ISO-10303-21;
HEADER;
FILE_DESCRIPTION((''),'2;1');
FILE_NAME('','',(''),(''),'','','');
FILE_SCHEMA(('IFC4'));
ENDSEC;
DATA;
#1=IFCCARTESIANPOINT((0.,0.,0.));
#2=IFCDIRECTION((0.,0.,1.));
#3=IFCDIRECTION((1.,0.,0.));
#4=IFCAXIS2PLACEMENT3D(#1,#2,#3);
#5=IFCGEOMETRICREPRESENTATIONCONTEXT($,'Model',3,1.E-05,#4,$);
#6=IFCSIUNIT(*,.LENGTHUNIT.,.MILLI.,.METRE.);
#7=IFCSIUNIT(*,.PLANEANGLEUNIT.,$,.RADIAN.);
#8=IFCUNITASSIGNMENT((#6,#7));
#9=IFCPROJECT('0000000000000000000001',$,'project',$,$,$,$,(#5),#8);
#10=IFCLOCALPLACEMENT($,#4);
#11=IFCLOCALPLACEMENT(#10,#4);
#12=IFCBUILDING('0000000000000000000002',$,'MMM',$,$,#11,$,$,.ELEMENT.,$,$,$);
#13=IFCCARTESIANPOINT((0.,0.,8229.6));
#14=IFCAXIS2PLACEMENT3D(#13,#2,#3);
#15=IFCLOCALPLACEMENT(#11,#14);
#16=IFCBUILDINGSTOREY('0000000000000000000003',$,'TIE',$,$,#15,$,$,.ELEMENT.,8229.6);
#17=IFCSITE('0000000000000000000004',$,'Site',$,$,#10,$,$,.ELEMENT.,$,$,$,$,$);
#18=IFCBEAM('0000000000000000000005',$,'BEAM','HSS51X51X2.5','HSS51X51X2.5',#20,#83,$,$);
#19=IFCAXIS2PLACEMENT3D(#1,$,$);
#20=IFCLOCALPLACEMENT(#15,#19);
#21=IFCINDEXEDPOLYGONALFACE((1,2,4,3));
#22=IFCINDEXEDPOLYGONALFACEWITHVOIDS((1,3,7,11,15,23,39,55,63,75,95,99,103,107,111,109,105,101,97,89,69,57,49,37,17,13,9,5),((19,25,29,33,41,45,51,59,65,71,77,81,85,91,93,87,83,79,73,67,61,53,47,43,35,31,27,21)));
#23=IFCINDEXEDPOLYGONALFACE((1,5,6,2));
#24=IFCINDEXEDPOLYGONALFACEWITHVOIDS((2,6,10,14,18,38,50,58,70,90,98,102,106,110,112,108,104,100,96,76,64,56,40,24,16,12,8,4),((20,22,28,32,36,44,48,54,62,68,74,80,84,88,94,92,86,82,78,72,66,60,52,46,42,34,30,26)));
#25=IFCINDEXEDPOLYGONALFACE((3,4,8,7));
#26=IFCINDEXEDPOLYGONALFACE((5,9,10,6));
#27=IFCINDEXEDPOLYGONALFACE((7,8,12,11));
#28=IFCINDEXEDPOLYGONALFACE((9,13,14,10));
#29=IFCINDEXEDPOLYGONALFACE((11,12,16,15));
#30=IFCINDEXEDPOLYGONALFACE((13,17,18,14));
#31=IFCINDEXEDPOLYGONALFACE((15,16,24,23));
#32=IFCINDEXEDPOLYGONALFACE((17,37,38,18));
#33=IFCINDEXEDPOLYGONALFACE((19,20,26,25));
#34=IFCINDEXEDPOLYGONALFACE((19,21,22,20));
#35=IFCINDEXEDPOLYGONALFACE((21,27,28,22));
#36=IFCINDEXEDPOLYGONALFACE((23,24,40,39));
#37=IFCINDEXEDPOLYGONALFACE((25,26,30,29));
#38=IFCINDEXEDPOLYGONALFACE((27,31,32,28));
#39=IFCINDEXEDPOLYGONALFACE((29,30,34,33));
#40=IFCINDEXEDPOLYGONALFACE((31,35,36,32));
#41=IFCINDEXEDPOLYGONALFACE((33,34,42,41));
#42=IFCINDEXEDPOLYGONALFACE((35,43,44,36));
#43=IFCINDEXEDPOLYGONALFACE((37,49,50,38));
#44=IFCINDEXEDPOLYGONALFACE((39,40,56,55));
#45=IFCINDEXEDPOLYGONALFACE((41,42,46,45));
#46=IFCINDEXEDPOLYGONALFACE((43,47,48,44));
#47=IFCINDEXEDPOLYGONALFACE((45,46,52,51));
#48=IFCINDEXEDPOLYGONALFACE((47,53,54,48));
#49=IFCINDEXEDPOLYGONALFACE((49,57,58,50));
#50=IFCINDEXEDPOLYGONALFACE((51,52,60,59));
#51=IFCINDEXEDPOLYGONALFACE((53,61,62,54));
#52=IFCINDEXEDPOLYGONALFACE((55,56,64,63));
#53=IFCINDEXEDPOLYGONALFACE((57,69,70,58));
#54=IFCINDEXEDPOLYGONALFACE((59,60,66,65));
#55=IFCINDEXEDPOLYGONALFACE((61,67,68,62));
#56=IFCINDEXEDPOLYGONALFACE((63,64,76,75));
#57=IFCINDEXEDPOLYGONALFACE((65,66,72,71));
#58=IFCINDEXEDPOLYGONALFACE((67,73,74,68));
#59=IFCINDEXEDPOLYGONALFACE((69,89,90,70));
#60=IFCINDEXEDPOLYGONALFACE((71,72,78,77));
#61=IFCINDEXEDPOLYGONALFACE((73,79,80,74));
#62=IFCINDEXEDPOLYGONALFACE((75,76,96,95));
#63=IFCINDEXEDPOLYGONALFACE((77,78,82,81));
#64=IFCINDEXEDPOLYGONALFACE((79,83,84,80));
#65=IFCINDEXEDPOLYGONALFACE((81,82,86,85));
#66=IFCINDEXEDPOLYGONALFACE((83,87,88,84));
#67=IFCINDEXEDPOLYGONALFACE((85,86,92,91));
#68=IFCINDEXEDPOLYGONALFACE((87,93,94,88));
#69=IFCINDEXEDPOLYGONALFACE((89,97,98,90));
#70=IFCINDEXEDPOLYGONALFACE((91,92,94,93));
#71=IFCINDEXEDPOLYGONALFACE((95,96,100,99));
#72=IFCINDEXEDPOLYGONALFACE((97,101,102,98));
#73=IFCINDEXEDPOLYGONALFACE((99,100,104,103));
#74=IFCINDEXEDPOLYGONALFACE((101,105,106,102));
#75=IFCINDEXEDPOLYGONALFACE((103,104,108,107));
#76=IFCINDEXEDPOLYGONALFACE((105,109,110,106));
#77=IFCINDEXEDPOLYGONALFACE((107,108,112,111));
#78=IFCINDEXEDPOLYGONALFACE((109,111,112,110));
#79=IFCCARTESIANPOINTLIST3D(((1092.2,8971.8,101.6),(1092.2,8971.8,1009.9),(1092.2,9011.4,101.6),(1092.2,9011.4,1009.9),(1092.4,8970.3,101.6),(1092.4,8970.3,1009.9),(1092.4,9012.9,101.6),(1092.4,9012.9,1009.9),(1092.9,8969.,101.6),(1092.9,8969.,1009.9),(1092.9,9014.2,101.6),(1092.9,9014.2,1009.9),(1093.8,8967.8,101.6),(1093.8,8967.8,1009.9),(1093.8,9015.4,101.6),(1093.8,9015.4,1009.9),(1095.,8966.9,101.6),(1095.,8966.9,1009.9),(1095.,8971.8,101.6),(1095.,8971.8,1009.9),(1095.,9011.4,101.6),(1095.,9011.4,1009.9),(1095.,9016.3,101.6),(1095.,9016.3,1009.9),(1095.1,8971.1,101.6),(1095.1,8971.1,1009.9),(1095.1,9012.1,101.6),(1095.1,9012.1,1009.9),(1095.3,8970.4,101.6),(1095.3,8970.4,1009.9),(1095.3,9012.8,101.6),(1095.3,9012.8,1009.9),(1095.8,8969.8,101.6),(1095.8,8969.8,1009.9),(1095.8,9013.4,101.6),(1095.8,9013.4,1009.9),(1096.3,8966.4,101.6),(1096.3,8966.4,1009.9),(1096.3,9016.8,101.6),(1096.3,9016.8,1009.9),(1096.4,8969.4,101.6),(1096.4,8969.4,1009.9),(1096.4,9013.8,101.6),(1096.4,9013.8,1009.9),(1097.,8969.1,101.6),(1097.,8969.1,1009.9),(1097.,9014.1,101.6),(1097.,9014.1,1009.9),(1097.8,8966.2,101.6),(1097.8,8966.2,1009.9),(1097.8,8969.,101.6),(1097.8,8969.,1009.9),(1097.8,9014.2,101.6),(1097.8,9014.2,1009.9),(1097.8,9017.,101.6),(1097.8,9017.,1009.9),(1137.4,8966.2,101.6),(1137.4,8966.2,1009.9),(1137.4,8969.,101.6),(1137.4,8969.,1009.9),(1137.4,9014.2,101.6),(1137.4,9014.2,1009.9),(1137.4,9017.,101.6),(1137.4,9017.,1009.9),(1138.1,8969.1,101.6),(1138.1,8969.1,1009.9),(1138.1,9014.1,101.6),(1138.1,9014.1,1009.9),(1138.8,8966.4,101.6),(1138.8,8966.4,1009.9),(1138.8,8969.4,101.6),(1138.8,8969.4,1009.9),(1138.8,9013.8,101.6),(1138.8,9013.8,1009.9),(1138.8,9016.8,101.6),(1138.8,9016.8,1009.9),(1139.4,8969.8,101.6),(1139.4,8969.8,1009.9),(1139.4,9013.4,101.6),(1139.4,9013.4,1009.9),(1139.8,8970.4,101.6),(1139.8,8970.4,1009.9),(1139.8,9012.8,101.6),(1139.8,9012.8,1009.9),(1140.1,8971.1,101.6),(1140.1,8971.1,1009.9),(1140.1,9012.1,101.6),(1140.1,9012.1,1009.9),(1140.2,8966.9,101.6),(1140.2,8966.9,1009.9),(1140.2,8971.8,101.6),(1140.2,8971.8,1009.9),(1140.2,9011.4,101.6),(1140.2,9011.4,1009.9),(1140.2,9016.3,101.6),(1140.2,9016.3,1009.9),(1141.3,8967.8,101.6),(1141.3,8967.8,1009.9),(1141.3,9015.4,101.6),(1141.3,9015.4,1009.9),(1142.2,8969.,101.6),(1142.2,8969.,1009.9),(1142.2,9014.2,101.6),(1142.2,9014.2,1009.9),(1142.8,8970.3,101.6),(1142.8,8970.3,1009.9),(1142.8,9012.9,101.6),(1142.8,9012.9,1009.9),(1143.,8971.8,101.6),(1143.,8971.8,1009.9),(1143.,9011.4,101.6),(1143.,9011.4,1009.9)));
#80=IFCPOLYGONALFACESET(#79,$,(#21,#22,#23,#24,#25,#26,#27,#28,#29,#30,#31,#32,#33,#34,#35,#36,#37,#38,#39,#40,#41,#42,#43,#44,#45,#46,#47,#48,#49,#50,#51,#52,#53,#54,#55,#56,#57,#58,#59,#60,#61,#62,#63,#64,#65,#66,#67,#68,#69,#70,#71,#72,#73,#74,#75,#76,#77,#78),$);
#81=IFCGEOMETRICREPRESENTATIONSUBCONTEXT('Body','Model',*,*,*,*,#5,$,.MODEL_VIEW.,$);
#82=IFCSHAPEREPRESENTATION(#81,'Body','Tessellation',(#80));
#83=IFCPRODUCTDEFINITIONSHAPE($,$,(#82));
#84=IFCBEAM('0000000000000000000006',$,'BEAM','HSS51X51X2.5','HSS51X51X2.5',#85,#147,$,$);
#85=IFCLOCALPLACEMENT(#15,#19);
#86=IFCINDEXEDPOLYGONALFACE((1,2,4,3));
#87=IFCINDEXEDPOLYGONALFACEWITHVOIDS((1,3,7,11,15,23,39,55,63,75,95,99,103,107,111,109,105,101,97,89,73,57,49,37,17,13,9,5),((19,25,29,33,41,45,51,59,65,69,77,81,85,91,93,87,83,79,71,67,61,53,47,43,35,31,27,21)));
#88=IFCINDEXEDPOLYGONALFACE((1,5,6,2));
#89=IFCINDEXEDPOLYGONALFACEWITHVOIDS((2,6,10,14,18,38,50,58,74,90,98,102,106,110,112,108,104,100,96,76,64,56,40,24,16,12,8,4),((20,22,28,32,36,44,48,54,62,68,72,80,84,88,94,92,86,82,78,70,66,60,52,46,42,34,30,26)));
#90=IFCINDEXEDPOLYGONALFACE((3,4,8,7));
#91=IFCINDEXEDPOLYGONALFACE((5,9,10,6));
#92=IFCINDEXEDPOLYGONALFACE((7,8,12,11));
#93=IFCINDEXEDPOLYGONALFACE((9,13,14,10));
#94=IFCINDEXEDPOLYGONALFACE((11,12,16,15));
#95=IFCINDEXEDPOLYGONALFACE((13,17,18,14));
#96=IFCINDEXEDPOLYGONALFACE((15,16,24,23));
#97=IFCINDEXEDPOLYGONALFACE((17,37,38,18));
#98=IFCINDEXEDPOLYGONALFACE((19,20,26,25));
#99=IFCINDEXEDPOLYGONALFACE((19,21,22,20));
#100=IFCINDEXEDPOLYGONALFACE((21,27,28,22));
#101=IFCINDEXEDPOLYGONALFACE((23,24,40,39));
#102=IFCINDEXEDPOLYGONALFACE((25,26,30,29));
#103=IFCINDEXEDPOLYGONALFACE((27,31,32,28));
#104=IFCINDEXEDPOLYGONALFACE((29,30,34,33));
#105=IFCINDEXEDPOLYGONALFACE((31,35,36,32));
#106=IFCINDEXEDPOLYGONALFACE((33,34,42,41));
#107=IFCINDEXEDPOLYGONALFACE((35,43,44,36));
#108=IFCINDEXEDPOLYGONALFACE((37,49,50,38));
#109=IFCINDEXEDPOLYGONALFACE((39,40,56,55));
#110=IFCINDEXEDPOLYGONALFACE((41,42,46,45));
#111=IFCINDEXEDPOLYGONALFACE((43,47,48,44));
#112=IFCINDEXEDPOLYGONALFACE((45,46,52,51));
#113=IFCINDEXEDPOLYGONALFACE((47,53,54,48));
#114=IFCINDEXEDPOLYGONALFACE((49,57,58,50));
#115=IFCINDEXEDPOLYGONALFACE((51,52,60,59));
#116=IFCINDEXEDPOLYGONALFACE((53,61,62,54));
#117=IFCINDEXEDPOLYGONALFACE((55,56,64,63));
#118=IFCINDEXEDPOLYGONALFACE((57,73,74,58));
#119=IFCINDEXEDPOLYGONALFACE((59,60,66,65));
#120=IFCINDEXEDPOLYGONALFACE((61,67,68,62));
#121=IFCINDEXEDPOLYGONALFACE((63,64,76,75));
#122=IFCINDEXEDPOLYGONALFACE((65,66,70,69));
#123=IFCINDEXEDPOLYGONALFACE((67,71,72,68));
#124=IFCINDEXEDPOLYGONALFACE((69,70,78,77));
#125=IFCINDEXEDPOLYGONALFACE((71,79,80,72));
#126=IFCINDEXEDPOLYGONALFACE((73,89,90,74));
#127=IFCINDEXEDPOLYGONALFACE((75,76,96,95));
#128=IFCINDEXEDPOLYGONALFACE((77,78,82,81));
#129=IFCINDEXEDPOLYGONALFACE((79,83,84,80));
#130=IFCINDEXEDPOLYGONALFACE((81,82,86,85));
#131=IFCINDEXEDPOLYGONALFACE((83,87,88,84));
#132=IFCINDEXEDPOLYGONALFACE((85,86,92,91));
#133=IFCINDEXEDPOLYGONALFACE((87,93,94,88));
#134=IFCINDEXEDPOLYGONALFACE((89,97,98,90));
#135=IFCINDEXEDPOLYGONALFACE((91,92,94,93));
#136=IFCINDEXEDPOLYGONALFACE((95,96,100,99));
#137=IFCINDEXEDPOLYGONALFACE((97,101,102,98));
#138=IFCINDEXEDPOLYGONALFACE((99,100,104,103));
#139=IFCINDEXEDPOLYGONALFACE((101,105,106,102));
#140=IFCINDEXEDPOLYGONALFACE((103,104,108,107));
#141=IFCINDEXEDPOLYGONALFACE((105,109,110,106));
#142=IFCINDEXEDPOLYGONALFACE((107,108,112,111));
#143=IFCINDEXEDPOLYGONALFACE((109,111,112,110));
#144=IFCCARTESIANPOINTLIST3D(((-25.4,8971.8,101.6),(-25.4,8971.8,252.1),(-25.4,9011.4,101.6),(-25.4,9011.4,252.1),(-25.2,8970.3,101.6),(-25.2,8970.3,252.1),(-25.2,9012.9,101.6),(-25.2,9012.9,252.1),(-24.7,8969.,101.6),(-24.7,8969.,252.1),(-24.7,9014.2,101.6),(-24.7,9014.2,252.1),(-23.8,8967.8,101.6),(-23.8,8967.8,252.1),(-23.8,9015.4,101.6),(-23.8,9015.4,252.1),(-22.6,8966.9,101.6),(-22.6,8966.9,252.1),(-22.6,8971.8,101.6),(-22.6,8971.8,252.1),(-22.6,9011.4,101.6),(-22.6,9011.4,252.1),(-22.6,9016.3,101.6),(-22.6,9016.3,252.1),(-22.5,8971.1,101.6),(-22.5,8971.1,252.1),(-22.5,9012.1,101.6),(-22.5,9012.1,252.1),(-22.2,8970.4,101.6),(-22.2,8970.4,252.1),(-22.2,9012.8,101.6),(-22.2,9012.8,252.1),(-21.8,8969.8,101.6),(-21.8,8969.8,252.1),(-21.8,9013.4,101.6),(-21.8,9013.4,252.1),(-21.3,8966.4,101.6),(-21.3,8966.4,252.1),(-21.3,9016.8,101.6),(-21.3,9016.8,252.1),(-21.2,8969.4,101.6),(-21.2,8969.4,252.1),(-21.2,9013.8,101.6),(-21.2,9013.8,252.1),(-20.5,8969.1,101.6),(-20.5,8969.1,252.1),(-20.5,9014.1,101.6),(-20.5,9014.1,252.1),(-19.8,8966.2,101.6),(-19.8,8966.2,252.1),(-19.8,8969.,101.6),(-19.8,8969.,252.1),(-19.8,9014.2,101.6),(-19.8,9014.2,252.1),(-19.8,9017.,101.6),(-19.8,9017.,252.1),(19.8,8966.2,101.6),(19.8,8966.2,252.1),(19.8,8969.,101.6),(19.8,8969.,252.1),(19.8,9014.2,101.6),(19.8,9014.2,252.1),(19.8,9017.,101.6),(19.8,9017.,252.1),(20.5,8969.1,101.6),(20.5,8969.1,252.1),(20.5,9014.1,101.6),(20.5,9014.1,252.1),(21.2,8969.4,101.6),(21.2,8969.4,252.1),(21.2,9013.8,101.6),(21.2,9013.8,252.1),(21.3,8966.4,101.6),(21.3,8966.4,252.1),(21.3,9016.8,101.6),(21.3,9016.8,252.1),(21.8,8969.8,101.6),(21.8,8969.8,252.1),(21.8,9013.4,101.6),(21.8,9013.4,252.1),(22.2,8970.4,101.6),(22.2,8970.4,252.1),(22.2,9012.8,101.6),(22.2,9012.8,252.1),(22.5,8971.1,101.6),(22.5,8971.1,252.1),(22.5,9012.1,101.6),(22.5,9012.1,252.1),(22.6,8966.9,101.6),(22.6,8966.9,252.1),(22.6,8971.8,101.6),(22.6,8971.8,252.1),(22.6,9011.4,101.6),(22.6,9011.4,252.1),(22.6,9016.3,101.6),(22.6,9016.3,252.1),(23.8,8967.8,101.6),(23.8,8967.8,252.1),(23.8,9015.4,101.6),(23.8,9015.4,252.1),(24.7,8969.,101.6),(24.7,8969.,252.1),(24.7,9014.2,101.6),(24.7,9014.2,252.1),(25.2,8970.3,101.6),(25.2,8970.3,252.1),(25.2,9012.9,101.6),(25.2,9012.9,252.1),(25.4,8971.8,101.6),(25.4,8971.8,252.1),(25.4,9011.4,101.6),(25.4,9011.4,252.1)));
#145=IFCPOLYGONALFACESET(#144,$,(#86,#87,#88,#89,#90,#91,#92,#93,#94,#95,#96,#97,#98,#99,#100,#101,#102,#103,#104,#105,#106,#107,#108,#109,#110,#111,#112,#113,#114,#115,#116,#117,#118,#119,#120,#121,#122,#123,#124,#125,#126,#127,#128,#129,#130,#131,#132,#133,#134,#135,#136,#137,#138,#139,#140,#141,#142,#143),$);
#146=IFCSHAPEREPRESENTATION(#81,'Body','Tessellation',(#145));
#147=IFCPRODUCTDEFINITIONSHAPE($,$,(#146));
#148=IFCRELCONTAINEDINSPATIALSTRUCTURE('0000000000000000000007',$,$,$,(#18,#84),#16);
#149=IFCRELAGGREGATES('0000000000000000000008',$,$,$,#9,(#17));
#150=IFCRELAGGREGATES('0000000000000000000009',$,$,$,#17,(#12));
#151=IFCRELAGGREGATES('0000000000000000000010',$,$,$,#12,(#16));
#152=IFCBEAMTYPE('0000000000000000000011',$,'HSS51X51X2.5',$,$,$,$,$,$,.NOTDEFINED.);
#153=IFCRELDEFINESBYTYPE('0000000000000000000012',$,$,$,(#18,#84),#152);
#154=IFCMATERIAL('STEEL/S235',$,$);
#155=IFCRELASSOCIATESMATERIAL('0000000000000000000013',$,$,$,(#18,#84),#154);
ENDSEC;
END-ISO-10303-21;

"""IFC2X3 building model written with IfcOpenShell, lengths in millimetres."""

from ifc_helpers import new_model, si_unit, frame, origin_with_axes, origin_2d_with_axis, place, context, subcontext, project, spatial, hollow_rectangle, extrude, material, type_object, element, save


model = new_model("IFC2X3")

# Units and contexts
model_context = context("Model", 3, precision=1e-05, world=origin_with_axes())
body_context = subcontext(model_context, "Body", "Model", "MODEL_VIEW")
ifc_project = project(units=[si_unit("LENGTHUNIT", "METRE", prefix="MILLI"), si_unit("PLANEANGLEUNIT", "RADIAN")], contexts=[model_context])

# Site, building, storey
site_placement = place(None, origin_with_axes())
site = spatial("IfcSite", under=ifc_project, at=site_placement, Name="Site", CompositionType="ELEMENT")
building_placement = place(site_placement, origin_with_axes())
building = spatial("IfcBuilding", under=site, at=building_placement, Name="MMM", CompositionType="ELEMENT")
storey_placement = place(building_placement, frame((0.0, 0.0, 8229.6), z_axis=(0.0, 0.0, 1.0), x_axis=(1.0, 0.0, 0.0)))
storey = spatial("IfcBuildingStorey", under=building, at=storey_placement, Name="TIE", CompositionType="ELEMENT", Elevation=8229.6)

# Beams
ifc_material = material(Name="STEEL/S235")
beam_type_1 = type_object("IfcBeamType", Name="HSS51X51X2.5", PredefinedType="NOTDEFINED")
beam_1_placement = place(storey_placement, frame((1117.6, 8991.6, 1009.9), z_axis=(1.0, 0.0, 0.0), x_axis=(0.0, 0.0, -1.0)))
element("IfcBeam", 1, at=beam_1_placement, inside=storey, type_object=beam_type_1, material=ifc_material, Name="BEAM", Description="HSS51X51X2.5", ObjectType="HSS51X51X2.5", context=body_context, shape_type="SweptSolid", body=[
    extrude(hollow_rectangle(XDim=50.8, YDim=50.8, WallThickness=2.8, InnerFilletRadius=2.8, OuterFilletRadius=5.6, at=origin_2d_with_axis()), frame((908.3, 0.0, 0.0), z_axis=(-1.0, 0.0, 0.0), x_axis=(0.0, -1.0, 0.0)), (0.0, 0.0, 1.0), 908.3),
])
beam_2_placement = place(storey_placement, frame((0.0, 8991.6, 252.1), z_axis=(1.0, 0.0, 0.0), x_axis=(0.0, 0.0, -1.0)))
element("IfcBeam", 2, at=beam_2_placement, inside=storey, type_object=beam_type_1, material=ifc_material, Name="BEAM", Description="HSS51X51X2.5", ObjectType="HSS51X51X2.5", context=body_context, shape_type="SweptSolid", body=[
    extrude(hollow_rectangle(XDim=50.8, YDim=50.8, WallThickness=2.8, InnerFilletRadius=2.8, OuterFilletRadius=5.6, at=origin_2d_with_axis()), frame((150.5, 0.0, 0.0), z_axis=(-1.0, 0.0, 0.0), x_axis=(0.0, -1.0, 0.0)), (0.0, 0.0, 1.0), 150.5),
])

save(model, "model.ifc")
